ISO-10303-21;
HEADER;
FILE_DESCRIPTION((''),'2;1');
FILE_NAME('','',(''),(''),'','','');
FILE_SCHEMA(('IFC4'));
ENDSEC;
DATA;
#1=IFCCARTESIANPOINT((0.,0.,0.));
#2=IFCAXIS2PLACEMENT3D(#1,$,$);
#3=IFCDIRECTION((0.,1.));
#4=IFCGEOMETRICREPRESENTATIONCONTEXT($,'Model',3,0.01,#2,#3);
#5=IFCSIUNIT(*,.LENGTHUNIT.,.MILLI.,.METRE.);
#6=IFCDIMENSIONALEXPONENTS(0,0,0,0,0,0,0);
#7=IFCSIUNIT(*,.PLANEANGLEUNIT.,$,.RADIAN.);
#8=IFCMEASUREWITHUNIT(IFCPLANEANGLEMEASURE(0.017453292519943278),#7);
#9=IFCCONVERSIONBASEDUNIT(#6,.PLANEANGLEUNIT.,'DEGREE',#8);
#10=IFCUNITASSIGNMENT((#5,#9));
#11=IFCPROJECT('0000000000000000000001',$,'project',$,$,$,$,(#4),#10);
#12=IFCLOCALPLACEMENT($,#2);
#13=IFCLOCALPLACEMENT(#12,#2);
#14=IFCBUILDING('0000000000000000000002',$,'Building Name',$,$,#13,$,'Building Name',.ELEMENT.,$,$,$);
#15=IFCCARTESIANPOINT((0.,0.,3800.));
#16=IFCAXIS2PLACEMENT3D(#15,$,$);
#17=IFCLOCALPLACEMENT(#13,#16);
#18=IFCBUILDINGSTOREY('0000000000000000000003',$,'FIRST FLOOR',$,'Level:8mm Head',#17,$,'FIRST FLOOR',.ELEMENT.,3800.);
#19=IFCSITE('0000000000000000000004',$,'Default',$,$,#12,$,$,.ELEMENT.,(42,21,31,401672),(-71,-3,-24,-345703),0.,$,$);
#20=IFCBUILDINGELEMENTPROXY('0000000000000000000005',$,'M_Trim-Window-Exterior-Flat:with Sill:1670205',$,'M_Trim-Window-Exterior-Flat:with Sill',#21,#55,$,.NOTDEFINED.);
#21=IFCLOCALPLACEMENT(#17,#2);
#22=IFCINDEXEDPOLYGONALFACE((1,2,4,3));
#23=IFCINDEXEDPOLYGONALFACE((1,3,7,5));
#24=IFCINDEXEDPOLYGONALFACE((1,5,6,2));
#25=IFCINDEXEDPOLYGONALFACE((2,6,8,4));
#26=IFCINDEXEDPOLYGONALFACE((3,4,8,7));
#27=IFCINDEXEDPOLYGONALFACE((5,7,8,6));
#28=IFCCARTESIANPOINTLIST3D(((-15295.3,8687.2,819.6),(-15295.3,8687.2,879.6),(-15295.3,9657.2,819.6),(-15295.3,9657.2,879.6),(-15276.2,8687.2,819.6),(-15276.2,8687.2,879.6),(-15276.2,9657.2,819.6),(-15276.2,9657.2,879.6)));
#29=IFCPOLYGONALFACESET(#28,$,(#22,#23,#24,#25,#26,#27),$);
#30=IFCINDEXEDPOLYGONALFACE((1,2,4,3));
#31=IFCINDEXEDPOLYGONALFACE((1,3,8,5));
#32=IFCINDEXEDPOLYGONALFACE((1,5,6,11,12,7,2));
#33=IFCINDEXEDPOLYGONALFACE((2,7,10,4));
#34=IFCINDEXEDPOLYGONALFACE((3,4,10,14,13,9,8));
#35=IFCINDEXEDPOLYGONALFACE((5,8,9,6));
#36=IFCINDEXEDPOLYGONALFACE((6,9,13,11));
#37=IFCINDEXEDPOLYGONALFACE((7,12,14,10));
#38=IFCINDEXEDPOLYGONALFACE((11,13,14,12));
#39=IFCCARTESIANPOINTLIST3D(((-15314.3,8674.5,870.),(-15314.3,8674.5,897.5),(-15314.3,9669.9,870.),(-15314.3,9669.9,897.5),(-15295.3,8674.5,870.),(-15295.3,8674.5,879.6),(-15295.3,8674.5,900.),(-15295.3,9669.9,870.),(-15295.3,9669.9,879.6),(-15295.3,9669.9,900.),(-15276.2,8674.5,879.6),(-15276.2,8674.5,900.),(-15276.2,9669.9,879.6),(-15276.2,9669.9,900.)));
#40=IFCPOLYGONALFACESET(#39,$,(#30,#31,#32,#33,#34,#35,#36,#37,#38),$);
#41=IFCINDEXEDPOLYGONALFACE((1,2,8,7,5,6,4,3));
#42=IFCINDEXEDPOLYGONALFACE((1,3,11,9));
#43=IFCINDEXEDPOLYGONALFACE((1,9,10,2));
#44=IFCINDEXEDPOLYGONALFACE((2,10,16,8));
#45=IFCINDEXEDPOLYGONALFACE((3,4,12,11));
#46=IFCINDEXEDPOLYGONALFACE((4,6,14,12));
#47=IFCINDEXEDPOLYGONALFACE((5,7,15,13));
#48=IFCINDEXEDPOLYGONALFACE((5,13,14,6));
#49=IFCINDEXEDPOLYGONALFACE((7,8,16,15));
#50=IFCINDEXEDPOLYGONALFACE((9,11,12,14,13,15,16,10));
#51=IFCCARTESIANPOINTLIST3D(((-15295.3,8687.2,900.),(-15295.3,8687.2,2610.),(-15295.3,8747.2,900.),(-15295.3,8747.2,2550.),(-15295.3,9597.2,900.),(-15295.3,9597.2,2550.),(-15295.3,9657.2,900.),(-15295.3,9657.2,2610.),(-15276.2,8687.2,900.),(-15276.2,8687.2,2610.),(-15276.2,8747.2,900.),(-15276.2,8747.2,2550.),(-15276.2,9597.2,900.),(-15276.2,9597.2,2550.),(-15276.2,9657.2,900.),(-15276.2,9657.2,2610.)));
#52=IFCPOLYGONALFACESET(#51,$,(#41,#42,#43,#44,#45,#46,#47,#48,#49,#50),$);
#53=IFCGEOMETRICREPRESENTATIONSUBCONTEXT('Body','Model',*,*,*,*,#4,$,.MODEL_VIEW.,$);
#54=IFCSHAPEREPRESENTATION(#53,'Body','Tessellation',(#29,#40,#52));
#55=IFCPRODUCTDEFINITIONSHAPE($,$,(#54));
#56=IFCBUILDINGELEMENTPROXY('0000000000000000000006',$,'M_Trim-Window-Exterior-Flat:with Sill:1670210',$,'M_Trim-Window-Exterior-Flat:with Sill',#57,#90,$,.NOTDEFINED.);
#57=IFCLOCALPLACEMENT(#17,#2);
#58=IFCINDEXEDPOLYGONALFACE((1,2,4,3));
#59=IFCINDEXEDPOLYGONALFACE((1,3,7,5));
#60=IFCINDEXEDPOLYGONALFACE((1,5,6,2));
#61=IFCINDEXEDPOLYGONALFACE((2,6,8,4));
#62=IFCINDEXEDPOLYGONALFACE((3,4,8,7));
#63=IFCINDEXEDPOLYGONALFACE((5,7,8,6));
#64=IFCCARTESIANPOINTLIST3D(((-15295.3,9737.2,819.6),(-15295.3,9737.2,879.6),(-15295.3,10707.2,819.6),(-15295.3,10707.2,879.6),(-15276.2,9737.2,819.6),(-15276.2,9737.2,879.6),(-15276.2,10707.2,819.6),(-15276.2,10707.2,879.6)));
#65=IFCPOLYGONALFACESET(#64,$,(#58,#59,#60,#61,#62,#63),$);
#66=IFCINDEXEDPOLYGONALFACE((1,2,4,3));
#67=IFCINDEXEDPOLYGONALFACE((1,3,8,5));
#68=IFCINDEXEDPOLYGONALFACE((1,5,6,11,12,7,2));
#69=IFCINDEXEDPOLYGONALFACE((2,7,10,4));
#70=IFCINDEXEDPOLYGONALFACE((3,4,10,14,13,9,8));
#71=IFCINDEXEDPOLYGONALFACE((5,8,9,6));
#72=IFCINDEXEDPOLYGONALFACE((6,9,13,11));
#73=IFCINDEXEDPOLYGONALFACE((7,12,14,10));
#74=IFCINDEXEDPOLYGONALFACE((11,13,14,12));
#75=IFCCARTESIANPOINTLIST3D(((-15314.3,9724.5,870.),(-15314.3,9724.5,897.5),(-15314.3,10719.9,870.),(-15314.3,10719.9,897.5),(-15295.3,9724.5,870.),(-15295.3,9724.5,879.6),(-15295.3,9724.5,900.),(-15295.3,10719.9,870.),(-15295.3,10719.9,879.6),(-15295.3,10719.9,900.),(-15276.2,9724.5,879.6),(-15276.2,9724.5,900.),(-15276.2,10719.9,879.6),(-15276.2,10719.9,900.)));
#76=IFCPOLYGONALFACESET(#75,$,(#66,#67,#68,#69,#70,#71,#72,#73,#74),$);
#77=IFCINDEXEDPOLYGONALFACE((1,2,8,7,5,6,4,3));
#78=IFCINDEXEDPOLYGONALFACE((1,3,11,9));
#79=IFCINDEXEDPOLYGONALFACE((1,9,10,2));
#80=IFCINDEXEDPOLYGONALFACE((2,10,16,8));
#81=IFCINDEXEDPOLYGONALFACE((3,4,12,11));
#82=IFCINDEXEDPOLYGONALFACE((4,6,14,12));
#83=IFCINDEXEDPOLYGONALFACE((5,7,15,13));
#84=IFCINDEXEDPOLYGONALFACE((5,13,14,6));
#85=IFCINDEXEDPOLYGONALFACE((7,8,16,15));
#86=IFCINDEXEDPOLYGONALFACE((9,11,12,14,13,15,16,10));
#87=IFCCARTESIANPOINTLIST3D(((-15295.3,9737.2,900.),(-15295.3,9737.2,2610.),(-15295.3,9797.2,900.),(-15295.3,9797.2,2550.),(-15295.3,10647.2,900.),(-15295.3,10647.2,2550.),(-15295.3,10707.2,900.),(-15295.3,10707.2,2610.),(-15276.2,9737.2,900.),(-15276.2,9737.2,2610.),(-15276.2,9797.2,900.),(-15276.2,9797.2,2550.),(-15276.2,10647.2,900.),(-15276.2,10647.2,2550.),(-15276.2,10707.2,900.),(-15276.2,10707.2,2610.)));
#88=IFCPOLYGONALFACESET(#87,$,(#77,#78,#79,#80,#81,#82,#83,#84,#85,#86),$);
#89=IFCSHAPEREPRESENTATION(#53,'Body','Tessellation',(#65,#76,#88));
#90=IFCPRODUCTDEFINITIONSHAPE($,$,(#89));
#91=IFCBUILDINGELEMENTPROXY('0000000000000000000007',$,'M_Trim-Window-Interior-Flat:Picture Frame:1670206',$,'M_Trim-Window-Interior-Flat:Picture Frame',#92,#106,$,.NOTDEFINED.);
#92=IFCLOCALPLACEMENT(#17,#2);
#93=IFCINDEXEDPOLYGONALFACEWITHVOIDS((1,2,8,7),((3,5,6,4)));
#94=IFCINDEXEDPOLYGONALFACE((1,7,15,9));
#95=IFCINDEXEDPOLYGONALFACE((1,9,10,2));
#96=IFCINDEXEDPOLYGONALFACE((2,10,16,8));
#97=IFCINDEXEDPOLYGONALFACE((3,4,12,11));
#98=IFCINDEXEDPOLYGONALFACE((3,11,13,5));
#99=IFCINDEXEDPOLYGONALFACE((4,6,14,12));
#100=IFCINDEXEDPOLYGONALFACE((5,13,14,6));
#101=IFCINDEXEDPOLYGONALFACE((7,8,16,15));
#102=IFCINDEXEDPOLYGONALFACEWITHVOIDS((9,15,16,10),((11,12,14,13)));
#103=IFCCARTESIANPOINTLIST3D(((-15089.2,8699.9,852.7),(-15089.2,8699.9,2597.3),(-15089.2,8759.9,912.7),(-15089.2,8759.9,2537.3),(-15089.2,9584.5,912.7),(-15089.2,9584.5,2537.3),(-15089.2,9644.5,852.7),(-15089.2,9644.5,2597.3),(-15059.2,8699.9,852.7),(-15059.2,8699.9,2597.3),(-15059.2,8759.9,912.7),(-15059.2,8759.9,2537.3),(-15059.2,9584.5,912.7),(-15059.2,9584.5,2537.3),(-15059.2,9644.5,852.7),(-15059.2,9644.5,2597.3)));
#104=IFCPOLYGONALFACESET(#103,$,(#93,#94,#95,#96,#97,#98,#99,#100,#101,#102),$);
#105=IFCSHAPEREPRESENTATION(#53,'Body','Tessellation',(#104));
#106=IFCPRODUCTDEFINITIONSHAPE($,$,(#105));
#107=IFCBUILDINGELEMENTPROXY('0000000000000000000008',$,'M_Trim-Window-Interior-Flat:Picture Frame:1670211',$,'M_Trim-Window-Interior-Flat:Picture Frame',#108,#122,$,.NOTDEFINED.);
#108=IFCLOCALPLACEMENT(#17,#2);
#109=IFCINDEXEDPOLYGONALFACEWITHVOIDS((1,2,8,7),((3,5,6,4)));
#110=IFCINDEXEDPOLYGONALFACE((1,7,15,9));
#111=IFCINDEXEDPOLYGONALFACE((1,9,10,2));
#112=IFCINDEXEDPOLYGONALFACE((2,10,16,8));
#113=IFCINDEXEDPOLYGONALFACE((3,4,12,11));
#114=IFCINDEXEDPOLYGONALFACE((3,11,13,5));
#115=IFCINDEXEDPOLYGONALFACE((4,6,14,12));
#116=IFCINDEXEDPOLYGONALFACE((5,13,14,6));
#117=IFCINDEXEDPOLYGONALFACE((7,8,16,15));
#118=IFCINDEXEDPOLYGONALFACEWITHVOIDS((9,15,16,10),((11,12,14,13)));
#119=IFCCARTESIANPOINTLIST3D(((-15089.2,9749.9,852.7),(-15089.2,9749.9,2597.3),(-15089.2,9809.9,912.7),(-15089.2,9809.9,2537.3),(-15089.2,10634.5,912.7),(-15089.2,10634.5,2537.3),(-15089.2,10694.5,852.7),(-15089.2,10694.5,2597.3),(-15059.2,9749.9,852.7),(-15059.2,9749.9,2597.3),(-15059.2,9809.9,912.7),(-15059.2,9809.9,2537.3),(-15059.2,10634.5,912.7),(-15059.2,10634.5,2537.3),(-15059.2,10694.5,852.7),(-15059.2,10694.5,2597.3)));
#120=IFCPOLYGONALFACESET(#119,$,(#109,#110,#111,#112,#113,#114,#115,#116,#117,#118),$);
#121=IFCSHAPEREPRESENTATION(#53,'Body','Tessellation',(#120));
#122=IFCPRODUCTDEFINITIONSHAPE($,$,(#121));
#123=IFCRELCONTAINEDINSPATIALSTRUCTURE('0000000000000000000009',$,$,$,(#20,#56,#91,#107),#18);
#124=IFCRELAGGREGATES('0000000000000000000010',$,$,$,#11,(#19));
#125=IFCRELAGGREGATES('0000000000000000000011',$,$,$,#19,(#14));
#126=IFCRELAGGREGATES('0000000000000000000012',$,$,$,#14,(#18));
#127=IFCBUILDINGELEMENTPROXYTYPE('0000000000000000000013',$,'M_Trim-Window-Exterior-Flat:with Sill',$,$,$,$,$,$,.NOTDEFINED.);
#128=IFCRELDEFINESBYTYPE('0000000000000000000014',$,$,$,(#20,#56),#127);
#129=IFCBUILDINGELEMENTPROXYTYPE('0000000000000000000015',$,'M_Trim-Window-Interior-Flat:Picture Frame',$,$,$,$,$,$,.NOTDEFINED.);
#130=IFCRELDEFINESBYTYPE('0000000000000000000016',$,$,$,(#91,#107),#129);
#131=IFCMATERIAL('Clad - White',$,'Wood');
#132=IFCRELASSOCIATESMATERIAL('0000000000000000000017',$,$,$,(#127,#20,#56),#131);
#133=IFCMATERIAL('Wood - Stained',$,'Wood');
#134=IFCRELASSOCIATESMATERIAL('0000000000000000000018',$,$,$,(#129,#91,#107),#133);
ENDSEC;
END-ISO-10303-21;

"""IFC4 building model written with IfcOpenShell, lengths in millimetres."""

from ifc_helpers import new_model, entity, si_unit, converted_unit, direction, frame, origin, place, context, subcontext, project, spatial, indexed_curve, outline, extrude, source, transform, mapped, material, type_object, type_shapes, element, save


model = new_model("IFC4")

# Units and contexts
model_context = context("Model", 3, precision=0.01, world=origin(), true_north=direction((0.0, 1.0)))
body_context = subcontext(model_context, "Body", "Model", "MODEL_VIEW")
ifc_project = project(units=[si_unit("LENGTHUNIT", "METRE", prefix="MILLI"), converted_unit("PLANEANGLEUNIT", "DEGREE", entity("IfcPlaneAngleMeasure", 0.017453292519943278), si_unit("PLANEANGLEUNIT", "RADIAN"), dimensions=[0, 0, 0, 0, 0, 0, 0])], contexts=[model_context])

# Site, building, storey
site_placement = place(None, origin())
site = spatial("IfcSite", under=ifc_project, at=site_placement, Name="Default", CompositionType="ELEMENT", RefLatitude=(42, 21, 31, 401672), RefLongitude=(-71, -3, -24, -345703), RefElevation=0.0)
building_placement = place(site_placement, origin())
building = spatial("IfcBuilding", under=site, at=building_placement, Name="Building Name", LongName="Building Name", CompositionType="ELEMENT")
storey_placement = place(building_placement, frame((0.0, 0.0, 3800.0)))
storey = spatial("IfcBuildingStorey", under=building, at=storey_placement, Name="FIRST FLOOR", ObjectType="Level:8mm Head", LongName="FIRST FLOOR", CompositionType="ELEMENT", Elevation=3800.0)

# Shared definitions
ifc_material_1 = material(Name="Wood - Stained", Category="Wood")

# Building element proxies
ifc_material_2 = material(Name="Clad - White", Category="Wood")
building_element_proxy_type_1 = type_object("IfcBuildingElementProxyType", Name="M_Trim-Window-Exterior-Flat:with Sill", PredefinedType="NOTDEFINED", material=ifc_material_2)
shared_shape_1 = source(origin(), body_context, "Body", "SweptSolid", [
    extrude(outline(indexed_curve([(-485.0, -30.0), (485.0, -30.0), (485.0, 30.0), (-485.0, 30.0), (-485.0, -30.0)], self_intersect=False)), frame((0.0, -1700.4, 0.0), z_axis=(0.0, 0.0, 1.0), x_axis=(-1.0, 0.0, 0.0)), (0.0, 0.0, 1.0), 19.0),
    extrude(outline(indexed_curve([(-19.0, -15.2), (0.0, -15.2), (0.0, -5.7), (19.0, -5.7), (19.0, 14.8), (0.0, 14.8), (-19.0, 12.3), (-19.0, -15.2)], self_intersect=False)), frame((-497.7, -1664.8, 19.0), z_axis=(1.0, 0.0, 0.0), x_axis=(0.0, 0.0, -1.0)), (0.0, 0.0, 1.0), 995.4),
    extrude(outline(indexed_curve([(-870.0, -485.0), (840.0, -485.0), (840.0, -425.0), (-810.0, -425.0), (-810.0, 425.0), (840.0, 425.0), (840.0, 485.0), (-870.0, 485.0), (-870.0, -485.0)], self_intersect=False)), frame((0.0, -810.0, 0.0), z_axis=(0.0, 0.0, 1.0), x_axis=(0.0, -1.0, 0.0)), (0.0, 0.0, 1.0), 19.0),
])
type_shapes(building_element_proxy_type_1, [shared_shape_1])
for number, where, z_axis, x_axis, name in (
    (1, (-15276.2, 9172.2, 2550.0), (-1.0, 0.0, 0.0), (0.0, -1.0, 0.0), "M_Trim-Window-Exterior-Flat:with Sill:1670205"),
    (2, (-15276.2, 10222.2, 2550.0), (-1.0, 0.0, 0.0), (0.0, -1.0, 0.0), "M_Trim-Window-Exterior-Flat:with Sill:1670210"),
):
    element("IfcBuildingElementProxy", number, at=place(storey_placement, frame(where, z_axis=z_axis, x_axis=x_axis)), inside=storey, type_object=building_element_proxy_type_1, material=ifc_material_2, Name=name, ObjectType="M_Trim-Window-Exterior-Flat:with Sill", PredefinedType="NOTDEFINED", context=body_context, shape_type="MappedRepresentation", body=[
        mapped(shared_shape_1, transform((0.0, 0.0, 0.0), scale=1.0)),
    ])
building_element_proxy_type_2 = type_object("IfcBuildingElementProxyType", Name="M_Trim-Window-Interior-Flat:Picture Frame", PredefinedType="NOTDEFINED", material=ifc_material_1)
shared_shape_2 = source(origin(), body_context, "Body", "SweptSolid", [
    extrude(outline(indexed_curve([(-472.3, -872.3), (472.3, -872.3), (472.3, 872.3), (-472.3, 872.3), (-472.3, -872.3)], self_intersect=False), holes=[indexed_curve([(-412.3, -812.3), (-412.3, 812.3), (412.3, 812.3), (412.3, -812.3), (-412.3, -812.3)], self_intersect=False)]), frame((0.0, -825.0, 0.0), z_axis=(0.0, 0.0, 1.0), x_axis=(-1.0, 0.0, 0.0)), (0.0, 0.0, 1.0), 30.0),
])
type_shapes(building_element_proxy_type_2, [shared_shape_2])
for number, where, z_axis, x_axis, name in (
    (3, (-15089.2, 9172.2, 2550.0), (1.0, 0.0, 0.0), (0.0, 1.0, 0.0), "M_Trim-Window-Interior-Flat:Picture Frame:1670206"),
    (4, (-15089.2, 10222.2, 2550.0), (1.0, 0.0, 0.0), (0.0, 1.0, 0.0), "M_Trim-Window-Interior-Flat:Picture Frame:1670211"),
):
    element("IfcBuildingElementProxy", number, at=place(storey_placement, frame(where, z_axis=z_axis, x_axis=x_axis)), inside=storey, type_object=building_element_proxy_type_2, material=ifc_material_1, Name=name, ObjectType="M_Trim-Window-Interior-Flat:Picture Frame", PredefinedType="NOTDEFINED", context=body_context, shape_type="MappedRepresentation", body=[
        mapped(shared_shape_2, transform((0.0, 0.0, 0.0), scale=1.0)),
    ])

save(model, "model.ifc")
